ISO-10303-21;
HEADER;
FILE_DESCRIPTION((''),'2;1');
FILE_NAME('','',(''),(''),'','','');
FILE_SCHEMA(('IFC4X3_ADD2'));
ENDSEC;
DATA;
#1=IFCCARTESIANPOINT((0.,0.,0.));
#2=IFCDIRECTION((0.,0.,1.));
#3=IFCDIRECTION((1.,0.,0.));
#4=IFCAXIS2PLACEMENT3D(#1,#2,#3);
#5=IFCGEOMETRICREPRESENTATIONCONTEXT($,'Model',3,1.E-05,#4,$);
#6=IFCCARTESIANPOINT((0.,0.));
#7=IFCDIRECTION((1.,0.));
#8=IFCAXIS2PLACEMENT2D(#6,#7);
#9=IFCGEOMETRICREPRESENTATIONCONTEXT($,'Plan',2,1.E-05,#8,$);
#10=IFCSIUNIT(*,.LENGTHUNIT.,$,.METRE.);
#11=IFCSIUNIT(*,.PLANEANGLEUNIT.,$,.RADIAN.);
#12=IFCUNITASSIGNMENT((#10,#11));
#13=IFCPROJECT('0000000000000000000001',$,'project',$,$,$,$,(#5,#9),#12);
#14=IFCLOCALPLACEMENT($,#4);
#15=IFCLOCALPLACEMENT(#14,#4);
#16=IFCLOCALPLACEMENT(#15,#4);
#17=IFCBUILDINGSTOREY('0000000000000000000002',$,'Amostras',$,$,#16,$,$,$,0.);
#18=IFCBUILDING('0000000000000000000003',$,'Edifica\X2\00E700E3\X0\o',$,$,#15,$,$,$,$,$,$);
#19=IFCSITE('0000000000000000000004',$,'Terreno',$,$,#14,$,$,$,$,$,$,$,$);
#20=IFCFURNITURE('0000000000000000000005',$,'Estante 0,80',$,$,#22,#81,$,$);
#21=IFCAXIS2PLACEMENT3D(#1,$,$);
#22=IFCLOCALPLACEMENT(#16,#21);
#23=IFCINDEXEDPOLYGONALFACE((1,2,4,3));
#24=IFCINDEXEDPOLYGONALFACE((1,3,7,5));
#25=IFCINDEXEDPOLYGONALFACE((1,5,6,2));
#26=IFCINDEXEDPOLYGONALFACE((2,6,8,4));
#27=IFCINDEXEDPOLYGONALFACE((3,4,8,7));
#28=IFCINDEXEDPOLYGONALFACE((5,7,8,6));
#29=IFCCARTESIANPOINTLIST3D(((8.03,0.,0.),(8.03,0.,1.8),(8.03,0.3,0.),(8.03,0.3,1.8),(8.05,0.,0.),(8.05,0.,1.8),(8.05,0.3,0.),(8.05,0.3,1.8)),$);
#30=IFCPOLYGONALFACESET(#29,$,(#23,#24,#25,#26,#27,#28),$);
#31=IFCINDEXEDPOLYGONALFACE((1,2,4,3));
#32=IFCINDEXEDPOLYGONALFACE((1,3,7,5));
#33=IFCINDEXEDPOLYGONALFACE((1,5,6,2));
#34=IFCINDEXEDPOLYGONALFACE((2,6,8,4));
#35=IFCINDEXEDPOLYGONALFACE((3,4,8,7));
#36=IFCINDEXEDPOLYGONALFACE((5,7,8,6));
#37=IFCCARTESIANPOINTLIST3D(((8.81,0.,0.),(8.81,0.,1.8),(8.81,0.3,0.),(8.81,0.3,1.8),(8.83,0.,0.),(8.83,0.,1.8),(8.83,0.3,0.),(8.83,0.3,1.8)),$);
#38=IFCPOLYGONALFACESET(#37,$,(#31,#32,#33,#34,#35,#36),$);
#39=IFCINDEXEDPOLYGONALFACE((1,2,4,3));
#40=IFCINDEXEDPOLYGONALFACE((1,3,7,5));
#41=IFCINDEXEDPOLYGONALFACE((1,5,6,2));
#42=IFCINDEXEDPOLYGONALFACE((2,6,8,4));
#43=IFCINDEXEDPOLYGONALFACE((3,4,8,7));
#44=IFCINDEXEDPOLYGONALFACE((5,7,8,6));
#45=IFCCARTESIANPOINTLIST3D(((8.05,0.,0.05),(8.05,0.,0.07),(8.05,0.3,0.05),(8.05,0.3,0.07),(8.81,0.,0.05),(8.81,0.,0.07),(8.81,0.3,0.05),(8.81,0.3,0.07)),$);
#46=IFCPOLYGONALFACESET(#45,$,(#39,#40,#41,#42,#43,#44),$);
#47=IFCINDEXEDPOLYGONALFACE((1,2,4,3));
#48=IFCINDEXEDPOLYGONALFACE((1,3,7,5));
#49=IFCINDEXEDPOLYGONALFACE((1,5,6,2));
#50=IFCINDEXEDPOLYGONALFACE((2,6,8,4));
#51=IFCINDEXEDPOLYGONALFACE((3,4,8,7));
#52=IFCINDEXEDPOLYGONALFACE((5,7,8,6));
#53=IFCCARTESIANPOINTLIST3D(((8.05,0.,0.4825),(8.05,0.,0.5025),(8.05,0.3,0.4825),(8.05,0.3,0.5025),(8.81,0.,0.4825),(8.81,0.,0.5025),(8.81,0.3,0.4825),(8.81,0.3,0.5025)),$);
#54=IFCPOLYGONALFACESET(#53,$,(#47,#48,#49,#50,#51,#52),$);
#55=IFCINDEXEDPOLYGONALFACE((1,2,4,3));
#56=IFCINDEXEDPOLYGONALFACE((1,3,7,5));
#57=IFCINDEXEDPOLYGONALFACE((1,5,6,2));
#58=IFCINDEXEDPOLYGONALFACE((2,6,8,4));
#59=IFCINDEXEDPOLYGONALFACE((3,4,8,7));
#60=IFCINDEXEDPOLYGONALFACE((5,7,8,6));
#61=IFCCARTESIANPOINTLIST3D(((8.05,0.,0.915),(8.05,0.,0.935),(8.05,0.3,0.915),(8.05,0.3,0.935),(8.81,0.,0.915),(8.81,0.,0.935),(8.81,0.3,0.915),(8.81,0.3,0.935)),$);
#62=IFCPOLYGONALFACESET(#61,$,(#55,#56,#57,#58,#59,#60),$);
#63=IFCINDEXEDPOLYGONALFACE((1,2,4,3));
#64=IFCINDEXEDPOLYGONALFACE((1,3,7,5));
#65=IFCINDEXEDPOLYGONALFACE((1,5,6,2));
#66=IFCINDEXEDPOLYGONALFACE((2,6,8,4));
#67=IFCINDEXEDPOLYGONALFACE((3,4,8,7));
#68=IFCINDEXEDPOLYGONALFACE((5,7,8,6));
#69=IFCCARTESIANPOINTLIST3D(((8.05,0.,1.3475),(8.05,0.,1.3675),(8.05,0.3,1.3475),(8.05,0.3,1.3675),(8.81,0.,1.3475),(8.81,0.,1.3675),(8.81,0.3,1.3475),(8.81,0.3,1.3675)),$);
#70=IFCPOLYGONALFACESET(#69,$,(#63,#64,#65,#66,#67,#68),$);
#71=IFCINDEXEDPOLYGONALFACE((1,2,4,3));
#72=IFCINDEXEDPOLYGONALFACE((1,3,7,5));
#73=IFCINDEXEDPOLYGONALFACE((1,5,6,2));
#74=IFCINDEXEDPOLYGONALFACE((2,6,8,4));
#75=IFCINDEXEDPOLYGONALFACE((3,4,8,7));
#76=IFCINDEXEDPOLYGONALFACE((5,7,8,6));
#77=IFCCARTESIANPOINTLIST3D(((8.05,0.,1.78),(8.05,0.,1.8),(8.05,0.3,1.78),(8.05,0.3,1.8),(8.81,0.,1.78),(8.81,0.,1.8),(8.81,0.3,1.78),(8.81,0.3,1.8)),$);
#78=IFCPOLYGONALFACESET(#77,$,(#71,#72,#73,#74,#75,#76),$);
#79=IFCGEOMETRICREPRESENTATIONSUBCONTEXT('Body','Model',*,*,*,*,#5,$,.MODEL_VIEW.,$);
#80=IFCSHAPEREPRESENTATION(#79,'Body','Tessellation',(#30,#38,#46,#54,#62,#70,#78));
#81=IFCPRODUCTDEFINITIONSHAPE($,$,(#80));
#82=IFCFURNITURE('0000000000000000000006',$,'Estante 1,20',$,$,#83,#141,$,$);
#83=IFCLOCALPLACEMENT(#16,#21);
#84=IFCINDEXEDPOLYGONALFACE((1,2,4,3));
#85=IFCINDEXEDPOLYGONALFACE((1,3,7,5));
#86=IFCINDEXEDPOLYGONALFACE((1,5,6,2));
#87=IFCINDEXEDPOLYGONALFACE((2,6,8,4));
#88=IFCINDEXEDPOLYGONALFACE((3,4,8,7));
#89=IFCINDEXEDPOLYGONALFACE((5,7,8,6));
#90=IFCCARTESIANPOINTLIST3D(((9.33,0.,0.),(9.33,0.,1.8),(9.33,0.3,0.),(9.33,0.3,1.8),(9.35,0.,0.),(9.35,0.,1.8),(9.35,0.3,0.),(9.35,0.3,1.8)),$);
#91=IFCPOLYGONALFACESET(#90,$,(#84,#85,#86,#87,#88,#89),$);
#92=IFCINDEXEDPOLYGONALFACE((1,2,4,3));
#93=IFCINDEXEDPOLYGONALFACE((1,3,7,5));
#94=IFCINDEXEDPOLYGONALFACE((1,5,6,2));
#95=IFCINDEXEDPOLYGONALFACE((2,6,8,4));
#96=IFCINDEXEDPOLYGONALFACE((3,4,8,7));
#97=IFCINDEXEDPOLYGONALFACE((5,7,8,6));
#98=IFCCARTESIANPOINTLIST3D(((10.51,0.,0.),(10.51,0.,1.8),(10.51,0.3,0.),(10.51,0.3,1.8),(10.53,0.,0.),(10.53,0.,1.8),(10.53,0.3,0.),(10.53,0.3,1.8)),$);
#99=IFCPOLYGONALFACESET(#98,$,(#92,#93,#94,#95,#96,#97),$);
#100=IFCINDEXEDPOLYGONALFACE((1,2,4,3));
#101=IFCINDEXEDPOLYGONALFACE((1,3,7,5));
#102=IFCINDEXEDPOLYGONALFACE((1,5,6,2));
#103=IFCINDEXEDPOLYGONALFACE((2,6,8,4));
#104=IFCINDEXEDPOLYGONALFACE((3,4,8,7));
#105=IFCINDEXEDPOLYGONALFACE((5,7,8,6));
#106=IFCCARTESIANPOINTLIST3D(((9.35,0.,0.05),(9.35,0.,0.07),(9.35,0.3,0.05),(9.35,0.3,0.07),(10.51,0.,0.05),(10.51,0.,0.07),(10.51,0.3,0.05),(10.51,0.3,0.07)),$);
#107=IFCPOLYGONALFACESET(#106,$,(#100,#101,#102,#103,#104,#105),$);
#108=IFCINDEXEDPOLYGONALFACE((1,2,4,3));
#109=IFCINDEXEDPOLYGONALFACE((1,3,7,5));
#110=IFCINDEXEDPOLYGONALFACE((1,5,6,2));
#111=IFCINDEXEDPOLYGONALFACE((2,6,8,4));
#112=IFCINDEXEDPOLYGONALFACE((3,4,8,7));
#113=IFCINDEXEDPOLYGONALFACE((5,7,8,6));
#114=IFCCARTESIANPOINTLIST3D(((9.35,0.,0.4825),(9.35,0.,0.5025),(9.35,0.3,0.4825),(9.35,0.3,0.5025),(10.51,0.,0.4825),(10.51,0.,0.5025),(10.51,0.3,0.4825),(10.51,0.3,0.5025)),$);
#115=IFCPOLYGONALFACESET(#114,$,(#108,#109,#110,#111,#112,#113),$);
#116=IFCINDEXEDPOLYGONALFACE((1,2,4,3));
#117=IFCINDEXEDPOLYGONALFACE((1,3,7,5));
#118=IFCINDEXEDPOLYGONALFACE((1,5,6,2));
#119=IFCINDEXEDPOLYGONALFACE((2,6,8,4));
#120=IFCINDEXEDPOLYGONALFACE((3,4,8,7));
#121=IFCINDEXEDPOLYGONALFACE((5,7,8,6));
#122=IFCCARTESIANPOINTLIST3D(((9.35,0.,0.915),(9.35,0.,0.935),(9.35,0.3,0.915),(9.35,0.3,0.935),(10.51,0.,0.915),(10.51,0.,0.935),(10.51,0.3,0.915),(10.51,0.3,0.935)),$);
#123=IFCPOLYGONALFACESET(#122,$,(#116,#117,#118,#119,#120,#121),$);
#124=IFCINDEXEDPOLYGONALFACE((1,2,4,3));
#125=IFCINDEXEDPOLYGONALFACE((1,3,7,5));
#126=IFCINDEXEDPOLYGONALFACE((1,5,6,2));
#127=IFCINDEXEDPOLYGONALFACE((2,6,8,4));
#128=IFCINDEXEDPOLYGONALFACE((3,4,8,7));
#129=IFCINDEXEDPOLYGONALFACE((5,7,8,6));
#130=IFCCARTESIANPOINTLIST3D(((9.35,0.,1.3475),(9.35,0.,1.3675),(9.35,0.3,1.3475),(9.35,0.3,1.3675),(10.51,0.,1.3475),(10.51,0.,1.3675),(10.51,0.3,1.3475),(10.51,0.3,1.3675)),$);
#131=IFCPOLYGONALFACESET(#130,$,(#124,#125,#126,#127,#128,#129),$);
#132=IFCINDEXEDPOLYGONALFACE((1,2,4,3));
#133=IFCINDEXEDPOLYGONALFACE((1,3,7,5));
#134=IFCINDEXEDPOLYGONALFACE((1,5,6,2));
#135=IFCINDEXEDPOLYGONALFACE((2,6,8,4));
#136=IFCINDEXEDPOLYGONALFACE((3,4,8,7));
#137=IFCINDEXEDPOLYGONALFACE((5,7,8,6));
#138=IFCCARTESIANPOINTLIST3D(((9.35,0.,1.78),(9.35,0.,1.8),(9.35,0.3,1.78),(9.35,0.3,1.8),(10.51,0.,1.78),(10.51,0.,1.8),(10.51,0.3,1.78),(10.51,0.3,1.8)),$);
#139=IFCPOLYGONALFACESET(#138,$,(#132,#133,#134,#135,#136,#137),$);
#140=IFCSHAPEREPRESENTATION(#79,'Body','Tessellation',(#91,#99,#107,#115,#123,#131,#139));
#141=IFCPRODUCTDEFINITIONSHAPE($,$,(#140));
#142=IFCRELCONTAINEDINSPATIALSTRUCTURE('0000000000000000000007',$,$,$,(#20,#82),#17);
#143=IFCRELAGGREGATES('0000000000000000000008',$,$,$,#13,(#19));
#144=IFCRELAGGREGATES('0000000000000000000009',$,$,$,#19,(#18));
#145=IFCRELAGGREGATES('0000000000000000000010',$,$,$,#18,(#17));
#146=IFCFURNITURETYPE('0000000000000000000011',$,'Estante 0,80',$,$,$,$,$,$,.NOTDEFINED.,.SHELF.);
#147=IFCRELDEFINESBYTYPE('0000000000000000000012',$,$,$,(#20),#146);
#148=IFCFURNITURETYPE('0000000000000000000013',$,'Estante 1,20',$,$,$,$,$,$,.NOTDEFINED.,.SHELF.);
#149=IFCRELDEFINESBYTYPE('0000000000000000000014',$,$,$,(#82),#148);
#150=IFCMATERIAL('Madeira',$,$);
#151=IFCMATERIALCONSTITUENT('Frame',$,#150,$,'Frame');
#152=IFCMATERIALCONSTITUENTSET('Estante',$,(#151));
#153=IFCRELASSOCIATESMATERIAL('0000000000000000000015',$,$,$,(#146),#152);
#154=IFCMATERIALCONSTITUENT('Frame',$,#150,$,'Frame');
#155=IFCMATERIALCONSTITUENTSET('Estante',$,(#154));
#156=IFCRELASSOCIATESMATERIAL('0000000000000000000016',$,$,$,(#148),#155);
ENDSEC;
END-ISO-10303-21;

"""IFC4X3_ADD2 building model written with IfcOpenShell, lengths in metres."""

from ifc_helpers import new_model, si_unit, frame, frame_2d, origin, origin_with_axes, origin_2d_with_axis, place, context, subcontext, project, spatial, rectangle, extrude, material, constituent, constituent_set, type_object, element, save


model = new_model("IFC4X3_ADD2")

# Units and contexts
model_context = context("Model", 3, precision=1e-05, world=origin_with_axes())
plan_context = context("Plan", 2, precision=1e-05, world=origin_2d_with_axis())
body_context = subcontext(model_context, "Body", "Model", "MODEL_VIEW")
ifc_project = project(units=[si_unit("LENGTHUNIT", "METRE"), si_unit("PLANEANGLEUNIT", "RADIAN")], contexts=[model_context, plan_context])

# Site, building, storey
site_placement = place(None, origin_with_axes())
site = spatial("IfcSite", under=ifc_project, at=site_placement, Name="Terreno")
building_placement = place(site_placement, origin_with_axes())
building = spatial("IfcBuilding", under=site, at=building_placement, Name="Edificação")
storey_placement = place(building_placement, origin_with_axes())
storey = spatial("IfcBuildingStorey", under=building, at=storey_placement, Name="Amostras", Elevation=0.0)

# Furniture
ifc_material_1 = material(Name="Madeira")
ifc_constituent_1 = constituent(ifc_material_1, Name="Frame", Category="Frame")
ifc_constituent_set_1 = constituent_set(constituents=[ifc_constituent_1], Name="Estante")
furniture_type_1 = type_object("IfcFurnitureType", Name="Estante 0,80", AssemblyPlace="NOTDEFINED", PredefinedType="SHELF", material=ifc_constituent_set_1)
furniture_1_placement = place(storey_placement, frame((8.03, 0.0, 0.0), z_axis=(0.0, 0.0, 1.0), x_axis=(1.0, 0.0, 0.0)))
element("IfcFurniture", 1, at=furniture_1_placement, inside=storey, type_object=furniture_type_1, Name="Estante 0,80", context=body_context, shape_type="SweptSolid", body=[
    extrude(rectangle(XDim=0.02, YDim=0.3, at=frame_2d((0.01, 0.15), x_axis=(1.0, 0.0))), origin(), (0.0, 0.0, 1.0), 1.8),
    extrude(rectangle(XDim=0.02, YDim=0.3, at=frame_2d((0.79, 0.15), x_axis=(1.0, 0.0))), origin(), (0.0, 0.0, 1.0), 1.8),
    extrude(rectangle(XDim=0.76, YDim=0.3, at=frame_2d((0.4, 0.15), x_axis=(1.0, 0.0))), frame((0.0, 0.0, 0.05)), (0.0, 0.0, 1.0), 0.02),
    extrude(rectangle(XDim=0.76, YDim=0.3, at=frame_2d((0.4, 0.15), x_axis=(1.0, 0.0))), frame((0.0, 0.0, 0.4825)), (0.0, 0.0, 1.0), 0.02),
    extrude(rectangle(XDim=0.76, YDim=0.3, at=frame_2d((0.4, 0.15), x_axis=(1.0, 0.0))), frame((0.0, 0.0, 0.915)), (0.0, 0.0, 1.0), 0.02),
    extrude(rectangle(XDim=0.76, YDim=0.3, at=frame_2d((0.4, 0.15), x_axis=(1.0, 0.0))), frame((0.0, 0.0, 1.3475)), (0.0, 0.0, 1.0), 0.02),
    extrude(rectangle(XDim=0.76, YDim=0.3, at=frame_2d((0.4, 0.15), x_axis=(1.0, 0.0))), frame((0.0, 0.0, 1.78)), (0.0, 0.0, 1.0), 0.02),
])
ifc_constituent_2 = constituent(ifc_material_1, Name="Frame", Category="Frame")
ifc_constituent_set_2 = constituent_set(constituents=[ifc_constituent_2], Name="Estante")
furniture_type_2 = type_object("IfcFurnitureType", Name="Estante 1,20", AssemblyPlace="NOTDEFINED", PredefinedType="SHELF", material=ifc_constituent_set_2)
furniture_2_placement = place(storey_placement, frame((9.33, 0.0, 0.0), z_axis=(0.0, 0.0, 1.0), x_axis=(1.0, 0.0, 0.0)))
element("IfcFurniture", 2, at=furniture_2_placement, inside=storey, type_object=furniture_type_2, Name="Estante 1,20", context=body_context, shape_type="SweptSolid", body=[
    extrude(rectangle(XDim=0.02, YDim=0.3, at=frame_2d((0.01, 0.15), x_axis=(1.0, 0.0))), origin(), (0.0, 0.0, 1.0), 1.8),
    extrude(rectangle(XDim=0.02, YDim=0.3, at=frame_2d((1.19, 0.15), x_axis=(1.0, 0.0))), origin(), (0.0, 0.0, 1.0), 1.8),
    extrude(rectangle(XDim=1.16, YDim=0.3, at=frame_2d((0.6, 0.15), x_axis=(1.0, 0.0))), frame((0.0, 0.0, 0.05)), (0.0, 0.0, 1.0), 0.02),
    extrude(rectangle(XDim=1.16, YDim=0.3, at=frame_2d((0.6, 0.15), x_axis=(1.0, 0.0))), frame((0.0, 0.0, 0.4825)), (0.0, 0.0, 1.0), 0.02),
    extrude(rectangle(XDim=1.16, YDim=0.3, at=frame_2d((0.6, 0.15), x_axis=(1.0, 0.0))), frame((0.0, 0.0, 0.915)), (0.0, 0.0, 1.0), 0.02),
    extrude(rectangle(XDim=1.16, YDim=0.3, at=frame_2d((0.6, 0.15), x_axis=(1.0, 0.0))), frame((0.0, 0.0, 1.3475)), (0.0, 0.0, 1.0), 0.02),
    extrude(rectangle(XDim=1.16, YDim=0.3, at=frame_2d((0.6, 0.15), x_axis=(1.0, 0.0))), frame((0.0, 0.0, 1.78)), (0.0, 0.0, 1.0), 0.02),
])

save(model, "model.ifc")
